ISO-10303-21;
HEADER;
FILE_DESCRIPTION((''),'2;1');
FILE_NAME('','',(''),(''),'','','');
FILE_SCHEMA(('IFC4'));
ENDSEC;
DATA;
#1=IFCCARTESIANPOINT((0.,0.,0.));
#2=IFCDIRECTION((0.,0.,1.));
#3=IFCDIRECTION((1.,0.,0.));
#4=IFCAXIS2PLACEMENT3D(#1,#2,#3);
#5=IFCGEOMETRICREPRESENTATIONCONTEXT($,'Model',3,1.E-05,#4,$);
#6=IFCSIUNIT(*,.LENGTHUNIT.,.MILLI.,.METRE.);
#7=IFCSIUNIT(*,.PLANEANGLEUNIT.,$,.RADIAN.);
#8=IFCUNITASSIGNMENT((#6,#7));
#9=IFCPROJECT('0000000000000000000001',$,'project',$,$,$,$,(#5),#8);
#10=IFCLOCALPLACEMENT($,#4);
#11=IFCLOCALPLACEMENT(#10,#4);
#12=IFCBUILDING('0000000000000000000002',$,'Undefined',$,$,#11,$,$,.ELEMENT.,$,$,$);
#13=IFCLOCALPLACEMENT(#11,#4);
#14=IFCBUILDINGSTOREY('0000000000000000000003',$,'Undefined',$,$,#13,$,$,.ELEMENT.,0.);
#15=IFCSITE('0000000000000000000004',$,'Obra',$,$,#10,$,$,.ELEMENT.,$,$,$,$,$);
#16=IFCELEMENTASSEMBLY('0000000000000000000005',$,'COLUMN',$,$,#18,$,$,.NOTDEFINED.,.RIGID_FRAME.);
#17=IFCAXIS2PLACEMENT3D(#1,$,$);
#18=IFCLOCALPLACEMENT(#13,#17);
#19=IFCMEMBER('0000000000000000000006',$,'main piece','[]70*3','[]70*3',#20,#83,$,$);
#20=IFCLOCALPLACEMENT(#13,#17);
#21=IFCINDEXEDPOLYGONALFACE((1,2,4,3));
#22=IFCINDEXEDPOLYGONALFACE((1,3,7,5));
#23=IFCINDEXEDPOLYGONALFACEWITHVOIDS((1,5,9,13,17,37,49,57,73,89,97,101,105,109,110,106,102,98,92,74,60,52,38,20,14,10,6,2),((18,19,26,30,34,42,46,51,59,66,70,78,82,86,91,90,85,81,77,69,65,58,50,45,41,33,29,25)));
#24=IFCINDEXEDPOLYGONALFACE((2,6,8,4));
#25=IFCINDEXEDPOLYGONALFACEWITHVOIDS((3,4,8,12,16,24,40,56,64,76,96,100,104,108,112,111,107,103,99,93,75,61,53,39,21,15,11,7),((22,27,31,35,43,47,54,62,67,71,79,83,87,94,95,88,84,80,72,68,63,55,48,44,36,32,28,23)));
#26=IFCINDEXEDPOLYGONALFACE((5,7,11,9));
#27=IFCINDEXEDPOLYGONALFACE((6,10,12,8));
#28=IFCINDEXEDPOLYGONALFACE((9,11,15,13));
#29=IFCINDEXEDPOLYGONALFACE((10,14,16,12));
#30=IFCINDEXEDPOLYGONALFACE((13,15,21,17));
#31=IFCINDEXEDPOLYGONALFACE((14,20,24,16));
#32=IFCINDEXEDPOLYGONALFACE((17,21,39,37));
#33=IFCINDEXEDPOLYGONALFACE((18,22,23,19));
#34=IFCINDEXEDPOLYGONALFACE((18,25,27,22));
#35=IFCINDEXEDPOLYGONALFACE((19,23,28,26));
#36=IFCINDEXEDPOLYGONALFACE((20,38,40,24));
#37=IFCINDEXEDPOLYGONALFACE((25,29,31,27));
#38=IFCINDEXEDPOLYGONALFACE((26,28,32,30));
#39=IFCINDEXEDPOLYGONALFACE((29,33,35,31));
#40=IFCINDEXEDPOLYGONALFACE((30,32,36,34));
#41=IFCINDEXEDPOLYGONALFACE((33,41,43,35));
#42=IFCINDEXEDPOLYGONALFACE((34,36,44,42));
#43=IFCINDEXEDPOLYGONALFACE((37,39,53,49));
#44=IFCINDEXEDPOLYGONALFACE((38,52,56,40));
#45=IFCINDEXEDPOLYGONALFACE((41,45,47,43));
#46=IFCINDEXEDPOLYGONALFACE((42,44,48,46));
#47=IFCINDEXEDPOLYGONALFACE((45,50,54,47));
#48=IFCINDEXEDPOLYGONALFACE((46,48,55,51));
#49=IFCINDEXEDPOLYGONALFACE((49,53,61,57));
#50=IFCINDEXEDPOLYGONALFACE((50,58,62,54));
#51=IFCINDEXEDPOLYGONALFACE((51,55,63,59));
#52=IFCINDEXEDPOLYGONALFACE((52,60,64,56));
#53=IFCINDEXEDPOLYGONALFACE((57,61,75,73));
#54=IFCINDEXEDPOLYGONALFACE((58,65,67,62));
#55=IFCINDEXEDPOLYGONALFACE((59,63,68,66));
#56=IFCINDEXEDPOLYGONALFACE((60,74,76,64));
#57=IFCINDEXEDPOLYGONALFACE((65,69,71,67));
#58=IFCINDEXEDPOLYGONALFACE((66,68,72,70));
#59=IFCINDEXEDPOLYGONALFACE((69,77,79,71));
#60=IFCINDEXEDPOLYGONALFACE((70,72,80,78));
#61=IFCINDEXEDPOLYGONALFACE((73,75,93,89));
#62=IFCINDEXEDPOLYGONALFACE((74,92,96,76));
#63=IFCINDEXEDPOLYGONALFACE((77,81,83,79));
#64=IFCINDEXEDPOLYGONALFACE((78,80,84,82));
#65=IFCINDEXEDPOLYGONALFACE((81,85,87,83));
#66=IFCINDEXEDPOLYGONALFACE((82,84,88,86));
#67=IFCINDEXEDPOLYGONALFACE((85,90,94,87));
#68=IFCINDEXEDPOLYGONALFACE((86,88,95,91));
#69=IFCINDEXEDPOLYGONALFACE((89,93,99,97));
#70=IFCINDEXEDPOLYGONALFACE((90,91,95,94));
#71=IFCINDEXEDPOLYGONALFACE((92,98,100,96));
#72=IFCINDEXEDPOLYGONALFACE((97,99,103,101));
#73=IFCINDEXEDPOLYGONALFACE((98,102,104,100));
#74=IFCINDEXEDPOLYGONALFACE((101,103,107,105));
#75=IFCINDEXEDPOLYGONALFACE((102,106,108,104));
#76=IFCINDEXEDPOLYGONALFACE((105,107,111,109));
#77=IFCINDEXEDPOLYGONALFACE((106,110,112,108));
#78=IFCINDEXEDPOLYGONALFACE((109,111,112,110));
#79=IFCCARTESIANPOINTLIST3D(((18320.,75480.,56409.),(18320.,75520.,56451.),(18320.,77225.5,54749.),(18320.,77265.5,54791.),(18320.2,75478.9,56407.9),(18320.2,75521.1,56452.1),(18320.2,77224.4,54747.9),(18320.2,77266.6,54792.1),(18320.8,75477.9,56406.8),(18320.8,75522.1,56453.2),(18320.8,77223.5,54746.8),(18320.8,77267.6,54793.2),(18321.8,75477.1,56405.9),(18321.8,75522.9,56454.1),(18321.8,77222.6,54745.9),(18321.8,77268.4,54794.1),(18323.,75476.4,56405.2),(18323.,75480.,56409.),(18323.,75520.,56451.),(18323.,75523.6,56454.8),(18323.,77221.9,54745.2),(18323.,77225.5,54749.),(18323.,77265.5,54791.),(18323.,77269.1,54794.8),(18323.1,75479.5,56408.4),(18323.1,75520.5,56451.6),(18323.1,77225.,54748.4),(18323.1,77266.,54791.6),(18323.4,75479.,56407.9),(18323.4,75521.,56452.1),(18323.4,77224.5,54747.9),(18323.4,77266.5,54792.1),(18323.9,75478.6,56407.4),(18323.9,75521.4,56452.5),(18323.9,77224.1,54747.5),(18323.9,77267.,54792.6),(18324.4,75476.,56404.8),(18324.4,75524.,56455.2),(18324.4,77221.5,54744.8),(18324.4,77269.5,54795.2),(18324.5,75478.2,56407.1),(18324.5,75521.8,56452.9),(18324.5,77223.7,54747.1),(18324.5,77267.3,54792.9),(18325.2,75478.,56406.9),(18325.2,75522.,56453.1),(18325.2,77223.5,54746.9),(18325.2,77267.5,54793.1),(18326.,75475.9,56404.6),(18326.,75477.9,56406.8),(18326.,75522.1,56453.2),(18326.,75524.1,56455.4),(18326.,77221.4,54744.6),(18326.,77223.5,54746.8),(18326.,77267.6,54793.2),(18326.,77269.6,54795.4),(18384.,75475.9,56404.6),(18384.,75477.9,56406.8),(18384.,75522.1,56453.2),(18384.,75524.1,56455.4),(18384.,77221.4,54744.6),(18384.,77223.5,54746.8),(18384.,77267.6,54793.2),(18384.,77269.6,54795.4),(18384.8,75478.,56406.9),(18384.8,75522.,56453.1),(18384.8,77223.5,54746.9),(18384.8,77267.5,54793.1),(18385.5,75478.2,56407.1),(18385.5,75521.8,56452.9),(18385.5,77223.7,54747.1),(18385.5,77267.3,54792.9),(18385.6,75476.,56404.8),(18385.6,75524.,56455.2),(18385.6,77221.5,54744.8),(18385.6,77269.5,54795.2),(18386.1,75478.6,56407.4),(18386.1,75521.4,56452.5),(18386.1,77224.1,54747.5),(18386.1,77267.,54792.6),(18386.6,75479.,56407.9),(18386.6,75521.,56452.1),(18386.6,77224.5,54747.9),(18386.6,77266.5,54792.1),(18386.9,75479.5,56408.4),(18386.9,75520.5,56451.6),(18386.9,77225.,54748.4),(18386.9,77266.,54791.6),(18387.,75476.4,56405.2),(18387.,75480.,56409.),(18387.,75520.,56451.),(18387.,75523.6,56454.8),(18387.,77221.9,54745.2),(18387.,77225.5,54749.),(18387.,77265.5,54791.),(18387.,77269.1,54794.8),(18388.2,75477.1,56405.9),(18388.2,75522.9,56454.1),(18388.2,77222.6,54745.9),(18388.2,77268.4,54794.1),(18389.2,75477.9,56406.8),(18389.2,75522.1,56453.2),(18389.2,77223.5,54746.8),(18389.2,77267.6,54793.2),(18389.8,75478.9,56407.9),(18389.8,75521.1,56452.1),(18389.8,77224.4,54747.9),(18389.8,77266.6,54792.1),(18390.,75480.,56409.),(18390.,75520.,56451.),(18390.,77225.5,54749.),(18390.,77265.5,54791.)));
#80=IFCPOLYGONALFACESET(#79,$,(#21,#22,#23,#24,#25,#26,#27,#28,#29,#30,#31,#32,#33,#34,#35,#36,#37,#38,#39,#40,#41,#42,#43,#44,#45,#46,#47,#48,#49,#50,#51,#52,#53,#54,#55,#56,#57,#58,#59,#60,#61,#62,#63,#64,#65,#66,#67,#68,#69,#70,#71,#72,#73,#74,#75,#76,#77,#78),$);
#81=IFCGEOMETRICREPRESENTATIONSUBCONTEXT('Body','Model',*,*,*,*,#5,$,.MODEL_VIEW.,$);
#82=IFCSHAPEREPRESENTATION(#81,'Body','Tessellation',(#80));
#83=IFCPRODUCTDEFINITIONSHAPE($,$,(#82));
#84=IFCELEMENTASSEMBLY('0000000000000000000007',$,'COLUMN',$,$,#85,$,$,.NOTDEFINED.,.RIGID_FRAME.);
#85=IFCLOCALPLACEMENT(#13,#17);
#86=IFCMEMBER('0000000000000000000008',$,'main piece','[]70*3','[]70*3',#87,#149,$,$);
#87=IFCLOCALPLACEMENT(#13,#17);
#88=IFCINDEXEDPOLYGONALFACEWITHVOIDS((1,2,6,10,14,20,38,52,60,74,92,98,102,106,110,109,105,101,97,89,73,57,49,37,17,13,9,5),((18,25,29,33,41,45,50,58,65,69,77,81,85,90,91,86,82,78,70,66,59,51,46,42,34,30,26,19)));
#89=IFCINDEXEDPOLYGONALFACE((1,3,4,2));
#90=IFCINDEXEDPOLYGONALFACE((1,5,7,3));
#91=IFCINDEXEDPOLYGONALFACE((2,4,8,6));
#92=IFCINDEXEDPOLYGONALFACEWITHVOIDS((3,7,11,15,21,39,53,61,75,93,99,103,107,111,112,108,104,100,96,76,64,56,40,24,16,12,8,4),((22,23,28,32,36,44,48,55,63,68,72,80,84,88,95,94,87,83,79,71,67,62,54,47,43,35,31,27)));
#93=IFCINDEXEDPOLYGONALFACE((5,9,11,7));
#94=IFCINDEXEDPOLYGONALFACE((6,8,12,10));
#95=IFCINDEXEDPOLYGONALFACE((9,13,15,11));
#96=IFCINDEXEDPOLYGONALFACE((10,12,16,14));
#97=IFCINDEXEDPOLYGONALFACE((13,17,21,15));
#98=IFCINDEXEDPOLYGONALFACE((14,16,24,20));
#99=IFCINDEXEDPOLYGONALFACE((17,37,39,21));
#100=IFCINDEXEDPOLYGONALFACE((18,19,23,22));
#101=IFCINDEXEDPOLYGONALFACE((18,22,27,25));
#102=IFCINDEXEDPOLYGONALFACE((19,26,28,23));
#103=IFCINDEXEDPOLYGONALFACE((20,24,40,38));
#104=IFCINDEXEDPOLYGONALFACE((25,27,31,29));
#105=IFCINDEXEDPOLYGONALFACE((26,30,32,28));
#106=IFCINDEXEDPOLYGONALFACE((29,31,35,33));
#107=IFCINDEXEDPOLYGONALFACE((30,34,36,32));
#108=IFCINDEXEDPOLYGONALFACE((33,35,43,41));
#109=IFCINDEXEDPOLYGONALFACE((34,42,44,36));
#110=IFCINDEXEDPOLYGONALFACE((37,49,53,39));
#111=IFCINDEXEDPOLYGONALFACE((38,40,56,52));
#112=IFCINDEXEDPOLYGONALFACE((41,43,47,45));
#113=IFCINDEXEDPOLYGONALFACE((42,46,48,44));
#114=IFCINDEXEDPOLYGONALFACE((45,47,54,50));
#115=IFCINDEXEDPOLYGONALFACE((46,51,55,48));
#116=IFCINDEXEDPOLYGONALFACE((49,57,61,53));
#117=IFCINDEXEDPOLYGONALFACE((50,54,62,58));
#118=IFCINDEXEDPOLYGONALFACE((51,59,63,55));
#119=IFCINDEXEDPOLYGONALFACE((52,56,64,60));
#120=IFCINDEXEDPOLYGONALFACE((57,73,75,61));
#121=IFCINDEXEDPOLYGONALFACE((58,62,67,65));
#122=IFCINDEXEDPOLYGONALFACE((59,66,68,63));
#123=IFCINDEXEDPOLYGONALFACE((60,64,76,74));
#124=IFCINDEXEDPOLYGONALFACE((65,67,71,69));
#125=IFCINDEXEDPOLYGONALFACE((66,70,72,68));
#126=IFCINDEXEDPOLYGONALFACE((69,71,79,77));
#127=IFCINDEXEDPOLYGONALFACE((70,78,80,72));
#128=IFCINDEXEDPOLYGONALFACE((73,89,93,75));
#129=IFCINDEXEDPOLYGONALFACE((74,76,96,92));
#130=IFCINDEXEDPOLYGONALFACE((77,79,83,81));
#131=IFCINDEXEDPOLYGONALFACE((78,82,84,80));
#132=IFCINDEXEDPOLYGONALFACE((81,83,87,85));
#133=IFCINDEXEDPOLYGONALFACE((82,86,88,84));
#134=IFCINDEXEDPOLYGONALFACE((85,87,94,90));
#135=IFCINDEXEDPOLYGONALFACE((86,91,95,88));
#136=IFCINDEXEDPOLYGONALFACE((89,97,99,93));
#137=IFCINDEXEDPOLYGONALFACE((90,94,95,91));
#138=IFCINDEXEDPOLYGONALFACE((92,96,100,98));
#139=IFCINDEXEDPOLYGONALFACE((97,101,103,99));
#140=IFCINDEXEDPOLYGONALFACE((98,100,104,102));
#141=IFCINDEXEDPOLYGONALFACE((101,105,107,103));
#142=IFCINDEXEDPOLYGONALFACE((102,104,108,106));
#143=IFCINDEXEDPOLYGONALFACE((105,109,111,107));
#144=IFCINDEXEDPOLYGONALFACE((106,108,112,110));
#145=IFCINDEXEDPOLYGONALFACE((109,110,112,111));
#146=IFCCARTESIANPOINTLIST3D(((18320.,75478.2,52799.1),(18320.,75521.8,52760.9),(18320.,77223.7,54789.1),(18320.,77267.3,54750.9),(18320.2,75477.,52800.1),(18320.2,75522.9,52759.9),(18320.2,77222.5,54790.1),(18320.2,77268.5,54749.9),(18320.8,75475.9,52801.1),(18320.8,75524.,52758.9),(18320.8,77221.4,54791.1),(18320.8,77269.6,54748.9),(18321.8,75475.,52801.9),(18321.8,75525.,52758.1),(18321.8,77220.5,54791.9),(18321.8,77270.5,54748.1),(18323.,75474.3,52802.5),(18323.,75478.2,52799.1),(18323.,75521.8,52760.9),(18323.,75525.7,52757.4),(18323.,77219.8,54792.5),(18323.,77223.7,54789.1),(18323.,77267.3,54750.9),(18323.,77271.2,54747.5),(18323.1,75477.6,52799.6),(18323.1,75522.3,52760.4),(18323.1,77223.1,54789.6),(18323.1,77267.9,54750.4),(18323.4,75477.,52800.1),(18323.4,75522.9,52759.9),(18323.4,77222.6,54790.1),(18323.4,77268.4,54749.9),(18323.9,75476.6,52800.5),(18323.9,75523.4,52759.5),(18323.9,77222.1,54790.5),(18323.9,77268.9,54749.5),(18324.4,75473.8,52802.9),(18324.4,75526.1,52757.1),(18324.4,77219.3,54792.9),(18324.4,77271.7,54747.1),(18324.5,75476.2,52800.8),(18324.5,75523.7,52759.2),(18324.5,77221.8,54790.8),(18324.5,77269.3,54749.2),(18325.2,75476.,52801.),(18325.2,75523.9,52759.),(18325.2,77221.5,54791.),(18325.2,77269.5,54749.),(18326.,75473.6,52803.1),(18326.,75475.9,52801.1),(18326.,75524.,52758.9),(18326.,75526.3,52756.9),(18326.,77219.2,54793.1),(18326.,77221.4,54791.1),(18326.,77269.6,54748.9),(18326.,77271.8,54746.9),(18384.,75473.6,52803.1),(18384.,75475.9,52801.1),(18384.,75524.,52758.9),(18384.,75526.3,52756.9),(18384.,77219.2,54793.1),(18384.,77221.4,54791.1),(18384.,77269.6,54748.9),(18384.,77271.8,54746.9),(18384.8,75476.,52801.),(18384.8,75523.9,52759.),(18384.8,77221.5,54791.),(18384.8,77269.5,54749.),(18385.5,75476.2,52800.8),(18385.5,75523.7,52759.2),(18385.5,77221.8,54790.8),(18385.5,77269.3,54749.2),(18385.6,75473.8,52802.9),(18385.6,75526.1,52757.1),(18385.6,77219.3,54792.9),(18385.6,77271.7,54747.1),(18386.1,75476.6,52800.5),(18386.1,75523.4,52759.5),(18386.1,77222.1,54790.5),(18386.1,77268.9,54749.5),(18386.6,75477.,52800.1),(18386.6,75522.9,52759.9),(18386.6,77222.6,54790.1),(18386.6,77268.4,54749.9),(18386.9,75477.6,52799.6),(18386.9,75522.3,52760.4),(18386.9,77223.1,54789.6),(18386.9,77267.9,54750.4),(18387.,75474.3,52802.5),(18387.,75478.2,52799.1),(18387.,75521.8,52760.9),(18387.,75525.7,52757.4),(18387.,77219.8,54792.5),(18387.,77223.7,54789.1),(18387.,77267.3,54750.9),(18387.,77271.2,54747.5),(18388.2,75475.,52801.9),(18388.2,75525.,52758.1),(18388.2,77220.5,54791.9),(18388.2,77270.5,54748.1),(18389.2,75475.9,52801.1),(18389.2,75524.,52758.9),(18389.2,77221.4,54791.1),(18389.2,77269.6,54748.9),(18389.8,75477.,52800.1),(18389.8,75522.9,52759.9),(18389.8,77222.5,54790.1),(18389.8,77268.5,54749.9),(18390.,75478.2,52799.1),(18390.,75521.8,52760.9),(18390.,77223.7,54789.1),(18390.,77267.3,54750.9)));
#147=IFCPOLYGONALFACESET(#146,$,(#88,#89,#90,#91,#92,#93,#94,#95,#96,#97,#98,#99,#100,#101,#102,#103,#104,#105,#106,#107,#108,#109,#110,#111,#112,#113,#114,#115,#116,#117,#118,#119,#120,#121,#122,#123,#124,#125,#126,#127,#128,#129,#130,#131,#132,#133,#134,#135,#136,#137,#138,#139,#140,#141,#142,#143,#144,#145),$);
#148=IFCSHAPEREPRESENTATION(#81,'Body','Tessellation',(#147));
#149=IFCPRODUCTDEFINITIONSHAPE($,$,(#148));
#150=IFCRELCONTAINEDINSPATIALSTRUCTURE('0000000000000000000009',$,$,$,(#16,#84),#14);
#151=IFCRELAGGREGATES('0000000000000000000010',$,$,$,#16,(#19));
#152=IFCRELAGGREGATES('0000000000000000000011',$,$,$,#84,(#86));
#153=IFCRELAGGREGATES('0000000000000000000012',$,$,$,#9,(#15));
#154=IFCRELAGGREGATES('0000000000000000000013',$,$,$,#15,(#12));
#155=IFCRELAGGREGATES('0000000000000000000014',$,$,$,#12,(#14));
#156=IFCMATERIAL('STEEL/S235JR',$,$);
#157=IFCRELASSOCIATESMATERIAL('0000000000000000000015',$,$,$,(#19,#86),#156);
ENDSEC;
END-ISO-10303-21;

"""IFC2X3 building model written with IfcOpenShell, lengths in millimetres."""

from ifc_helpers import new_model, si_unit, frame, origin_with_axes, origin_2d_with_axis, place, context, subcontext, project, spatial, hollow_rectangle, extrude, material, element, aggregate, save


model = new_model("IFC2X3")

# Units and contexts
model_context = context("Model", 3, precision=1e-05, world=origin_with_axes())
body_context = subcontext(model_context, "Body", "Model", "MODEL_VIEW")
ifc_project = project(units=[si_unit("LENGTHUNIT", "METRE", prefix="MILLI"), si_unit("PLANEANGLEUNIT", "RADIAN")], contexts=[model_context])

# Site, building, storey
site_placement = place(None, origin_with_axes())
site = spatial("IfcSite", under=ifc_project, at=site_placement, Name="Obra", CompositionType="ELEMENT")
building_placement = place(site_placement, origin_with_axes())
building = spatial("IfcBuilding", under=site, at=building_placement, Name="Undefined", CompositionType="ELEMENT")
storey_placement = place(building_placement, origin_with_axes())
storey = spatial("IfcBuildingStorey", under=building, at=storey_placement, Name="Undefined", CompositionType="ELEMENT", Elevation=0.0)

# Shared definitions
ifc_material = material(Name="STEEL/S235JR")

# Element assemblies, members
assembly_1_placement = place(storey_placement, origin_with_axes())
assembly_1 = element("IfcElementAssembly", 1, at=assembly_1_placement, inside=storey, Name="COLUMN", AssemblyPlace="NOTDEFINED", PredefinedType="RIGID_FRAME")
member_1_placement = place(assembly_1_placement, frame((18355.0, 77245.5, 54770.0), z_axis=(1.0, 0.0, 0.0), x_axis=(0.0, -0.724633, 0.689135)))
member_1 = element("IfcMember", 2, at=member_1_placement, material=ifc_material, Name="main piece", Description="[]70*3", ObjectType="[]70*3", context=body_context, shape_type="SweptSolid", body=[
    extrude(hollow_rectangle(XDim=70.0, YDim=70.0, WallThickness=3.0, InnerFilletRadius=3.0, OuterFilletRadius=6.0, at=origin_2d_with_axis()), frame((2408.8, 0.0, 0.0), z_axis=(-1.0, 0.0, 0.0), x_axis=(0.0, -1.0, 0.0)), (0.0, 0.0, 1.0), 2408.8),
])
aggregate(assembly_1, [member_1])
assembly_2_placement = place(storey_placement, origin_with_axes())
assembly_2 = element("IfcElementAssembly", 3, at=assembly_2_placement, inside=storey, Name="COLUMN", AssemblyPlace="NOTDEFINED", PredefinedType="RIGID_FRAME")
member_2_placement = place(assembly_2_placement, frame((18355.0, 75500.0, 52780.0), z_axis=(-1.0, 0.0, 0.0), x_axis=(0.0, 0.659423, 0.751772)))
member_2 = element("IfcMember", 4, at=member_2_placement, material=ifc_material, Name="main piece", Description="[]70*3", ObjectType="[]70*3", context=body_context, shape_type="SweptSolid", body=[
    extrude(hollow_rectangle(XDim=70.0, YDim=70.0, WallThickness=3.0, InnerFilletRadius=3.0, OuterFilletRadius=6.0, at=origin_2d_with_axis()), frame((2647.1, 0.0, 0.0), z_axis=(-1.0, 0.0, 0.0), x_axis=(0.0, -1.0, 0.0)), (0.0, 0.0, 1.0), 2647.1),
])
aggregate(assembly_2, [member_2])

save(model, "model.ifc")
